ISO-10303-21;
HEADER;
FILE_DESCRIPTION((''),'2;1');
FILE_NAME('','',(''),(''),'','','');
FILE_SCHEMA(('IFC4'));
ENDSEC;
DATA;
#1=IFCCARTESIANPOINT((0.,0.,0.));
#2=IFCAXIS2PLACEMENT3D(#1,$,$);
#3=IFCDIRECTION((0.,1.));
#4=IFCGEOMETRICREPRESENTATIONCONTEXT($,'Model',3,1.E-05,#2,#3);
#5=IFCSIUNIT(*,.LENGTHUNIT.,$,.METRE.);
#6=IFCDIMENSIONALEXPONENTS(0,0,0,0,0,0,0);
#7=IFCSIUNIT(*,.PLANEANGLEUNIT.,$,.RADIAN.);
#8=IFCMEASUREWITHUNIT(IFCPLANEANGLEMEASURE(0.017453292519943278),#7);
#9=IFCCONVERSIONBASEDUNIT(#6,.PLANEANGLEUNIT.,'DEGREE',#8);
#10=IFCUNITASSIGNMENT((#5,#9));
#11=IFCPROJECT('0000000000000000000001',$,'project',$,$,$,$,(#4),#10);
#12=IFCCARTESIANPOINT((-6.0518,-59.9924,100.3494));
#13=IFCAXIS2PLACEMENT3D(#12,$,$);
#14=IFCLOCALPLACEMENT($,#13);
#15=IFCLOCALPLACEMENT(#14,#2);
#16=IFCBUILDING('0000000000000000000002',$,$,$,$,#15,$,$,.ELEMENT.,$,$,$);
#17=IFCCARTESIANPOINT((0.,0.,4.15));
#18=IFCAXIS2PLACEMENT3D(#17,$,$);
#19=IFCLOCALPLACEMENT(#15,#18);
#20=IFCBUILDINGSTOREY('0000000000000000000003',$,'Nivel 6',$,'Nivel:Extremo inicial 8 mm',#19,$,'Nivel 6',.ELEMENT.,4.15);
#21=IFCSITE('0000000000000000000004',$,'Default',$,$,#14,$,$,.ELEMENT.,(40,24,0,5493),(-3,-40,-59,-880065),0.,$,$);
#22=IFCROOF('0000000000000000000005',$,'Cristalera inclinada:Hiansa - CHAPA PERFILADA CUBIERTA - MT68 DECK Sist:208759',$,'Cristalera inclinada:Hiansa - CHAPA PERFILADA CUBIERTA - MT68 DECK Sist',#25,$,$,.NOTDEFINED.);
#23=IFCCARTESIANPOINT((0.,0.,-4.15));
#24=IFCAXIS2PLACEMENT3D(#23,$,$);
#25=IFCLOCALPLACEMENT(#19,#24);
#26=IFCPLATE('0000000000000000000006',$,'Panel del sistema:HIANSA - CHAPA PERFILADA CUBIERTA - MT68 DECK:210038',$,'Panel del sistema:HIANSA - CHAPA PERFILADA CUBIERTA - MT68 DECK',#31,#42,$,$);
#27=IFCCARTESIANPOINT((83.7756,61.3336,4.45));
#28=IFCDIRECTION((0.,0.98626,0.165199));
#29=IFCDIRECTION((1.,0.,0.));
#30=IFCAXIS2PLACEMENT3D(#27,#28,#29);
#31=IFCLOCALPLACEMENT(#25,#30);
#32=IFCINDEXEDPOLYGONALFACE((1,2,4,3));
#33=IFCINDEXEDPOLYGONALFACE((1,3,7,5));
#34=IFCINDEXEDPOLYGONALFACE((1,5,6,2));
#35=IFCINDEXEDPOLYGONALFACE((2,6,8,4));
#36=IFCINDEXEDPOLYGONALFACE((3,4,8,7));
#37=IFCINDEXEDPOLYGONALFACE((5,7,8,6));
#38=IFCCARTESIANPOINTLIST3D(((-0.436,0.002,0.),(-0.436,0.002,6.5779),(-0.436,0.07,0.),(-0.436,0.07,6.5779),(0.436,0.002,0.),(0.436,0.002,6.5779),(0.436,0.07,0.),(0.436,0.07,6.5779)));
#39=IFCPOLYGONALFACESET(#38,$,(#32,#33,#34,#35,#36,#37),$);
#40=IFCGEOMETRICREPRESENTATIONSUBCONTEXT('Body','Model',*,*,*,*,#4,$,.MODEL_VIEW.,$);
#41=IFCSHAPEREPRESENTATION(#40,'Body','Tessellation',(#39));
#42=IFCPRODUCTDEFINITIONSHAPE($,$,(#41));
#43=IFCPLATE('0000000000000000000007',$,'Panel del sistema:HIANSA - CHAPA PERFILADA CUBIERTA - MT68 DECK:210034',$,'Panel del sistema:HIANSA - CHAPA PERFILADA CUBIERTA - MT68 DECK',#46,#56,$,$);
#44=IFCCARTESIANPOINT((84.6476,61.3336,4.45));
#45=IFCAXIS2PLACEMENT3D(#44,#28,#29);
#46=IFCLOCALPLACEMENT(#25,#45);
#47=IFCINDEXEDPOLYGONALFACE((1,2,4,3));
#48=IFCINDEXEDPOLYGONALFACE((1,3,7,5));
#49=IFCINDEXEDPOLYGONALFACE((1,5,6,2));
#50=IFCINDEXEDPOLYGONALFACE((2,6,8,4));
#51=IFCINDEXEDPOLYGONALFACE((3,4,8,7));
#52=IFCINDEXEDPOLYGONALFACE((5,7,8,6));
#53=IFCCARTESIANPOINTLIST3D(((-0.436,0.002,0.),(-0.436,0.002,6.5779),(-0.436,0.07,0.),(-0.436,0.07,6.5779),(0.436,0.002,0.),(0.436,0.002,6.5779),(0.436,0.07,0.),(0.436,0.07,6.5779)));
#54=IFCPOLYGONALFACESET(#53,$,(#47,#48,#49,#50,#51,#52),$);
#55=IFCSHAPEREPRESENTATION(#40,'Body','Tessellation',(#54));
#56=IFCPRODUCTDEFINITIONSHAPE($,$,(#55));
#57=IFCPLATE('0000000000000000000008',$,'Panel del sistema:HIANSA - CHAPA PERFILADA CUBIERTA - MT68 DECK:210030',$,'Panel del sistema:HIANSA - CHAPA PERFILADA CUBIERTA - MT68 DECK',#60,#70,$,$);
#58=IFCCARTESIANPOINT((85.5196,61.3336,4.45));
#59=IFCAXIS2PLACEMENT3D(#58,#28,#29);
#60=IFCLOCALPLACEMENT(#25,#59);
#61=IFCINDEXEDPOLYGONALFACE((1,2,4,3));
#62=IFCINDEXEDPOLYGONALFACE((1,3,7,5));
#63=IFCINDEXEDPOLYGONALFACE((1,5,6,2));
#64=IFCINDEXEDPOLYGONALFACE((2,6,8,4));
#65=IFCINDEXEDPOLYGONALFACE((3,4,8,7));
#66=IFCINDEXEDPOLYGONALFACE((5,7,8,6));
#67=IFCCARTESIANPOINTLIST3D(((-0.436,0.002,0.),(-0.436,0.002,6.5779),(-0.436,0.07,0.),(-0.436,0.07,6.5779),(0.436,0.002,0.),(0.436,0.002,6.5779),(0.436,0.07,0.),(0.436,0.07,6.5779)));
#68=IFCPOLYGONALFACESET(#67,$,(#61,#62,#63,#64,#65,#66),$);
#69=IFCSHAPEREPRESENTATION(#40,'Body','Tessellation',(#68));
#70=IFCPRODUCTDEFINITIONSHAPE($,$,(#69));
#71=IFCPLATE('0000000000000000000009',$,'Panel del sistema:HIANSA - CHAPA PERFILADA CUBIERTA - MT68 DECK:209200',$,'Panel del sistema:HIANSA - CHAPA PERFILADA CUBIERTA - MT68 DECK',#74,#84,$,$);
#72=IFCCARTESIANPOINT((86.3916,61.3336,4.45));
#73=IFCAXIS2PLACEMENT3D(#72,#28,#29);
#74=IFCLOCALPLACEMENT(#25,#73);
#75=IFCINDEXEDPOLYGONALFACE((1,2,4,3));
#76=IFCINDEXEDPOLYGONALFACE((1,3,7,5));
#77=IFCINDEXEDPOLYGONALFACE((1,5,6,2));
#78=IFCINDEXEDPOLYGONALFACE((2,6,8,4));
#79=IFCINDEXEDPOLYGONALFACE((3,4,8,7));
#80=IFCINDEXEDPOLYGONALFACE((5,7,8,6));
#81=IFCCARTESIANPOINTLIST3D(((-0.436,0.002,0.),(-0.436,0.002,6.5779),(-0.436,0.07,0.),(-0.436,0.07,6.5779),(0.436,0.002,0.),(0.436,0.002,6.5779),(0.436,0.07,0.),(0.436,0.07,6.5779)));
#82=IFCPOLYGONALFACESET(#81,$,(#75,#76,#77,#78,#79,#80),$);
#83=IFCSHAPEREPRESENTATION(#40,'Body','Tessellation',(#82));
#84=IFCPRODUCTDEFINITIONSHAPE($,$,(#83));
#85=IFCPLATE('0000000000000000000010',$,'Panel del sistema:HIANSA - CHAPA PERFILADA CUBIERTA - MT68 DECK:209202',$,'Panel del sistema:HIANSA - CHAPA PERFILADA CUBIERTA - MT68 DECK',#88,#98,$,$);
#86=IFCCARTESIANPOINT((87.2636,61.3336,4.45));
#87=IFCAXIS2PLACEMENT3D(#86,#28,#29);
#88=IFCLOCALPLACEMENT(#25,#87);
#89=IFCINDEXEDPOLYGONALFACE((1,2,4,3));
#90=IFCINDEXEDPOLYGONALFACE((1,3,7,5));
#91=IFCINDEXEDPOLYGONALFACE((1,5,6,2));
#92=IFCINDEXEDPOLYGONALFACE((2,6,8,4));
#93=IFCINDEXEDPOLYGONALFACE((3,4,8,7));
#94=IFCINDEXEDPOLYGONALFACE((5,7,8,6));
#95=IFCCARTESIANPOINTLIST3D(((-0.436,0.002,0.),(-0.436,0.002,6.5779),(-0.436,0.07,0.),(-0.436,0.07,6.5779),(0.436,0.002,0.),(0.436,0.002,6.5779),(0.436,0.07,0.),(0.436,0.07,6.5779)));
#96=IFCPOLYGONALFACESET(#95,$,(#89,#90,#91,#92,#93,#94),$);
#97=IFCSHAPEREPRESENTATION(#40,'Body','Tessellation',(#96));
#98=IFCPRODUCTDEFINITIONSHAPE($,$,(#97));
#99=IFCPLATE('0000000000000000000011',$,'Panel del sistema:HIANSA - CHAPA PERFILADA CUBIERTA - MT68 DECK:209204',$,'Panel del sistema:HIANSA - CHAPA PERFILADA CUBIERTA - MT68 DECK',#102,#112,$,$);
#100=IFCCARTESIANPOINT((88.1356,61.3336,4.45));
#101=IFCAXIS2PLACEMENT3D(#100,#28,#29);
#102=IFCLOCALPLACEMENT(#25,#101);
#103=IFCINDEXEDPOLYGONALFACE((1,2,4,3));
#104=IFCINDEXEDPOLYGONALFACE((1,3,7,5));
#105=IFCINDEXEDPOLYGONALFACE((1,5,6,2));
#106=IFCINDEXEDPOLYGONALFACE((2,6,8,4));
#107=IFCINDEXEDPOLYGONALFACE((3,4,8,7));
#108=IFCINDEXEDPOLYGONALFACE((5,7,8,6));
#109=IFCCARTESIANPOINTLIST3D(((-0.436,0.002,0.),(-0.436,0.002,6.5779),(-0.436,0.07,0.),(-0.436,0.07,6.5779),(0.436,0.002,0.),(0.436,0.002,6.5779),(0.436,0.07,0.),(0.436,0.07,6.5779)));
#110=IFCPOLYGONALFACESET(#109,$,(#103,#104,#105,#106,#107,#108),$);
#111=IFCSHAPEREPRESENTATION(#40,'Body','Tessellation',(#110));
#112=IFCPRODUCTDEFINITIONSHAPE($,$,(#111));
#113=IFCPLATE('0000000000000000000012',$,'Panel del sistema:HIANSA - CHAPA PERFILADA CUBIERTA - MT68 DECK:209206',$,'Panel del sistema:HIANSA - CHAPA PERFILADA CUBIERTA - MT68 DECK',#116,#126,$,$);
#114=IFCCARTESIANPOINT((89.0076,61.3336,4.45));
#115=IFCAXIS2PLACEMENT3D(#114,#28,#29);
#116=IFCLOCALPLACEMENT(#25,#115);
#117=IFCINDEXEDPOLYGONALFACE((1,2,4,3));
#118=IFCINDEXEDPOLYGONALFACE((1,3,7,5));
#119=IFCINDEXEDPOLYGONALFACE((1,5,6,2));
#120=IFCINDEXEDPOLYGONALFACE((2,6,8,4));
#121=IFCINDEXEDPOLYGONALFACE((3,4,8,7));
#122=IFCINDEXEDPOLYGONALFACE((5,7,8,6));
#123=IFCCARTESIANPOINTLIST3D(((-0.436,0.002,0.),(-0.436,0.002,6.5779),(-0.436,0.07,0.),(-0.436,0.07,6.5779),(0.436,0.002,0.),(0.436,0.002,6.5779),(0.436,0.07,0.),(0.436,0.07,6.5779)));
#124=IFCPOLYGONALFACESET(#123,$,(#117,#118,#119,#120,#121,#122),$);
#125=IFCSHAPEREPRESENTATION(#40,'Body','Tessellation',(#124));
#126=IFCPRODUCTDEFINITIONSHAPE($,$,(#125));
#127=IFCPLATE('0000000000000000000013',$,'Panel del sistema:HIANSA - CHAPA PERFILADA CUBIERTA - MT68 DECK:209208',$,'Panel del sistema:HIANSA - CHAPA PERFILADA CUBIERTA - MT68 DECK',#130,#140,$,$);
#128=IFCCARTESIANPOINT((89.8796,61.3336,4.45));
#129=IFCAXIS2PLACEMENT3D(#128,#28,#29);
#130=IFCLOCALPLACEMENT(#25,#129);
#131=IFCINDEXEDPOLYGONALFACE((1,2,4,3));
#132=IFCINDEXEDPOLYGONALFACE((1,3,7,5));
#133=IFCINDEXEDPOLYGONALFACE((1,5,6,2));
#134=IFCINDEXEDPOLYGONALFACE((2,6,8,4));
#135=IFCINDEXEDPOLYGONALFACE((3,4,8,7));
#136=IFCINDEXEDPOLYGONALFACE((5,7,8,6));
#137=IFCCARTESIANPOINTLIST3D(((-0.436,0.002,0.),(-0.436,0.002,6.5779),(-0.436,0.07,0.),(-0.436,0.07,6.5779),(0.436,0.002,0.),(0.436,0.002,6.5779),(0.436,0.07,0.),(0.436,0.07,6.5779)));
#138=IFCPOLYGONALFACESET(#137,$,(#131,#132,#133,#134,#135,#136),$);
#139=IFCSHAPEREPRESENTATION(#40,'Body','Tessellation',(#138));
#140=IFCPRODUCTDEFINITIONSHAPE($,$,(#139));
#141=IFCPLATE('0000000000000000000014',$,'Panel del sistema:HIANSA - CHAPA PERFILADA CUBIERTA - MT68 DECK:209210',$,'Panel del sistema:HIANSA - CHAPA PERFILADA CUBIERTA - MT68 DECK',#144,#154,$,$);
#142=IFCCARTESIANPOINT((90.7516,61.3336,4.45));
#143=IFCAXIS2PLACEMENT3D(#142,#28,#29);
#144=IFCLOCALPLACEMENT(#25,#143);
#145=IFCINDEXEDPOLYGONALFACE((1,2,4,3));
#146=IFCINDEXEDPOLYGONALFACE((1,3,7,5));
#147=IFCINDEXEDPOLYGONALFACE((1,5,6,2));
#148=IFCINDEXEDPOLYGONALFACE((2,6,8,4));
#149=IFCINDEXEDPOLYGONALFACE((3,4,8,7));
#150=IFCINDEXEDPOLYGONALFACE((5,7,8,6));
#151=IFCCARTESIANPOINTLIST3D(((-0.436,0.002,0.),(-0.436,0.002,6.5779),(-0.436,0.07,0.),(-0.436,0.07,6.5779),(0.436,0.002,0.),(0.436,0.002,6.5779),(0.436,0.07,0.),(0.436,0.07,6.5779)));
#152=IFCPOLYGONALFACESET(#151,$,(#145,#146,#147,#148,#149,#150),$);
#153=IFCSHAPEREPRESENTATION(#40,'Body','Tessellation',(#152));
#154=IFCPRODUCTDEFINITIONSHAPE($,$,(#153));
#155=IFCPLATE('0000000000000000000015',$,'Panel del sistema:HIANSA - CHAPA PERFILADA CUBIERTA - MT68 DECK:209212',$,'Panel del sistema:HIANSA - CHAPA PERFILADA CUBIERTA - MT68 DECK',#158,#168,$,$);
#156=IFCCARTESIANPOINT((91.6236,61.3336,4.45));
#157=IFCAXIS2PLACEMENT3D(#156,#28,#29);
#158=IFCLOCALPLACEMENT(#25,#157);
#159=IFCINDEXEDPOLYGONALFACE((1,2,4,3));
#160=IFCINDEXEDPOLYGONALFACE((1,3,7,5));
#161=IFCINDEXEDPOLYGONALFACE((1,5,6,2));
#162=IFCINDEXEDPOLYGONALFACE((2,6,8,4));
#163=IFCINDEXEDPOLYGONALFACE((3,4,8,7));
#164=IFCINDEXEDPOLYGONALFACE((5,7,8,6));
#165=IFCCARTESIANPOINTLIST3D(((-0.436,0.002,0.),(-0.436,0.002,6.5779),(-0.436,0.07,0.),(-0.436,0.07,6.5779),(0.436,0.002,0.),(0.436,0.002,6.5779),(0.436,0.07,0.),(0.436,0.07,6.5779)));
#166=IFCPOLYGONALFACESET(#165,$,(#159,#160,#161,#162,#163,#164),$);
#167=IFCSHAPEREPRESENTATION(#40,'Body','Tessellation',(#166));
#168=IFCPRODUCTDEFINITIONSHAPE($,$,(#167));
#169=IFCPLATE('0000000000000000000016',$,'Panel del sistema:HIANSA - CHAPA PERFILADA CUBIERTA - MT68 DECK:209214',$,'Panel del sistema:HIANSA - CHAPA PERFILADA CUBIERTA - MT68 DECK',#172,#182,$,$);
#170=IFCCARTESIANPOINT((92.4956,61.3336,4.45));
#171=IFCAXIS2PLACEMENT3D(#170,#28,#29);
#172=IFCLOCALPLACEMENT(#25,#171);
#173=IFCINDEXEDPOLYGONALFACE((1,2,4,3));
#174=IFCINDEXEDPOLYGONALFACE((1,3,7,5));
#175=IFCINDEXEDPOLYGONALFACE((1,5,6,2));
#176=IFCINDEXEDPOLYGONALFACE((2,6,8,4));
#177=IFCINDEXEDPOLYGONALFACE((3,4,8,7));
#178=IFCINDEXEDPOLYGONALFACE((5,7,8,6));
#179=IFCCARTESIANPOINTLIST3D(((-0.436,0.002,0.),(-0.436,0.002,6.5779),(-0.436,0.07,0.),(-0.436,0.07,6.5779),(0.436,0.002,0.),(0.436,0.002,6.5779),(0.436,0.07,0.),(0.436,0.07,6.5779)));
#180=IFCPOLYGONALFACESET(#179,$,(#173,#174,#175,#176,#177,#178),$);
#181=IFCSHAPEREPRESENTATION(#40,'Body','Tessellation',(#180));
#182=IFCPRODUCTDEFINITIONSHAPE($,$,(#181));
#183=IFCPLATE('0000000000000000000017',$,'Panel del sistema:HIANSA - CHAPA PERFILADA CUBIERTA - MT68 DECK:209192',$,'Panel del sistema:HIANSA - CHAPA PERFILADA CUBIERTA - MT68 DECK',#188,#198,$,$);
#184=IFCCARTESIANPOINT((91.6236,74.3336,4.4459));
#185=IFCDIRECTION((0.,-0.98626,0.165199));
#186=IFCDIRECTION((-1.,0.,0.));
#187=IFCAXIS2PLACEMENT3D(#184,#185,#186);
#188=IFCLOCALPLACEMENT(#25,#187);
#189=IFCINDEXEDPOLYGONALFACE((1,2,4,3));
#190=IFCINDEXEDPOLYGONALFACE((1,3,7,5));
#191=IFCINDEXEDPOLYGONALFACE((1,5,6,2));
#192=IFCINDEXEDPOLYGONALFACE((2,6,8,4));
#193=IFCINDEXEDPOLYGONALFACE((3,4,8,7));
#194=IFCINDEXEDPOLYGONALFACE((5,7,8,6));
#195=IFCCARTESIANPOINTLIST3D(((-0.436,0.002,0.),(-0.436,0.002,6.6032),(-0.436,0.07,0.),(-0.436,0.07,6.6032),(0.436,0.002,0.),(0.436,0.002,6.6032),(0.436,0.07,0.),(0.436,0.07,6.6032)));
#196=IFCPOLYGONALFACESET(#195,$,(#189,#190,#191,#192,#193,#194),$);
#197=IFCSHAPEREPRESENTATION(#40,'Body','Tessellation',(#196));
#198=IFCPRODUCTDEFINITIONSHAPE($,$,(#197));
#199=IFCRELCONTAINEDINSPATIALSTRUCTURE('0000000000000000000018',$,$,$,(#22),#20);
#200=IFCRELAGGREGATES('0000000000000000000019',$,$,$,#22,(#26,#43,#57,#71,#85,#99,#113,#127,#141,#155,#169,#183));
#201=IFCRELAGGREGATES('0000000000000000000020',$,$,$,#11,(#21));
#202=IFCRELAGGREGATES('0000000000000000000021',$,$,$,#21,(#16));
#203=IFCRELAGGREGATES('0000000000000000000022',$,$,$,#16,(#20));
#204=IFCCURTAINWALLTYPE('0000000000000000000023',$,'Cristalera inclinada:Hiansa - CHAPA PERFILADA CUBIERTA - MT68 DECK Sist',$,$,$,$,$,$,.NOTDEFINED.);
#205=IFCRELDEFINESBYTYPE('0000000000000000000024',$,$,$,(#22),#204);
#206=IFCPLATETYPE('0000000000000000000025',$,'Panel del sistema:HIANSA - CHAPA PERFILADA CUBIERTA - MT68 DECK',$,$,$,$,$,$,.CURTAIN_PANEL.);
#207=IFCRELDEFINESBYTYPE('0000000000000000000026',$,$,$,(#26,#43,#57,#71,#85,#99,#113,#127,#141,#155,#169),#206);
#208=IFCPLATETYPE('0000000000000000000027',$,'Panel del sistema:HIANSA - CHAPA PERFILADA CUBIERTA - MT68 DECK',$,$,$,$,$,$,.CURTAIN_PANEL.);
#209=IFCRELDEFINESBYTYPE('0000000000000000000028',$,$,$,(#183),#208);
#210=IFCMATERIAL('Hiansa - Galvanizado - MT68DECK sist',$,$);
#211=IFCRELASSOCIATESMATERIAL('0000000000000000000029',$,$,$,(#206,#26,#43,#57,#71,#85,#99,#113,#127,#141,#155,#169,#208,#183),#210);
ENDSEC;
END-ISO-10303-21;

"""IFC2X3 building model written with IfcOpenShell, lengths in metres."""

from ifc_helpers import new_model, entity, si_unit, converted_unit, direction, frame, origin, origin_2d_with_axis, place, context, subcontext, project, spatial, rectangle, extrude, source, transform, mapped, material, type_object, type_shapes, element, aggregate, save


model = new_model("IFC2X3")

# Units and contexts
model_context = context("Model", 3, precision=1e-05, world=origin(), true_north=direction((0.0, 1.0)))
body_context = subcontext(model_context, "Body", "Model", "MODEL_VIEW")
ifc_project = project(units=[si_unit("LENGTHUNIT", "METRE"), converted_unit("PLANEANGLEUNIT", "DEGREE", entity("IfcPlaneAngleMeasure", 0.017453292519943278), si_unit("PLANEANGLEUNIT", "RADIAN"), dimensions=[0, 0, 0, 0, 0, 0, 0])], contexts=[model_context])

# Site, building, storey
site_placement = place(None, frame((-6.0518, -59.9924, 100.3494)))
site = spatial("IfcSite", under=ifc_project, at=site_placement, Name="Default", CompositionType="ELEMENT", RefLatitude=(40, 24, 0, 5493), RefLongitude=(-3, -40, -59, -880065), RefElevation=0.0)
building_placement = place(site_placement, origin())
building = spatial("IfcBuilding", under=site, at=building_placement, CompositionType="ELEMENT")
storey_placement = place(building_placement, frame((0.0, 0.0, 4.15)))
storey = spatial("IfcBuildingStorey", under=building, at=storey_placement, Name="Nivel 6", ObjectType="Nivel:Extremo inicial 8 mm", LongName="Nivel 6", CompositionType="ELEMENT", Elevation=4.15)

# Roof, plates
curtain_wall_type = type_object("IfcCurtainWallType", Name="Cristalera inclinada:Hiansa - CHAPA PERFILADA CUBIERTA - MT68 DECK Sist", PredefinedType="NOTDEFINED")
roof_placement = place(storey_placement, frame((0.0, 0.0, -4.15)))
roof = element("IfcRoof", 1, at=roof_placement, inside=storey, type_object=curtain_wall_type, Name="Cristalera inclinada:Hiansa - CHAPA PERFILADA CUBIERTA - MT68 DECK Sist:208759", ObjectType="Cristalera inclinada:Hiansa - CHAPA PERFILADA CUBIERTA - MT68 DECK Sist", ShapeType="NOTDEFINED")
ifc_material_1 = material(Name="Hiansa - Galvanizado - MT68DECK sist")
plate_type_1 = type_object("IfcPlateType", Name="Panel del sistema:HIANSA - CHAPA PERFILADA CUBIERTA - MT68 DECK", PredefinedType="CURTAIN_PANEL", material=ifc_material_1)
shared_shape_1 = source(origin(), body_context, "Body", "SweptSolid", [
    extrude(rectangle(XDim=0.068, YDim=0.872, at=origin_2d_with_axis()), frame((0.0, 0.036, 0.0), z_axis=(0.0, 0.0, 1.0), x_axis=(0.0, 1.0, 0.0)), (0.0, 0.0, 1.0), 6.5779),
])
type_shapes(plate_type_1, [shared_shape_1])
plate_1_placement = place(roof_placement, frame((83.7756, 61.3336, 4.45), z_axis=(0.0, 0.98626, 0.165199), x_axis=(1.0, 0.0, 0.0)))
plate_1 = element("IfcPlate", 2, at=plate_1_placement, type_object=plate_type_1, material=ifc_material_1, Name="Panel del sistema:HIANSA - CHAPA PERFILADA CUBIERTA - MT68 DECK:210038", ObjectType="Panel del sistema:HIANSA - CHAPA PERFILADA CUBIERTA - MT68 DECK", context=body_context, shape_type="MappedRepresentation", body=[
    mapped(shared_shape_1, transform((0.0, 0.0, 0.0), scale=1.0)),
])
plate_2_placement = place(roof_placement, frame((84.6476, 61.3336, 4.45), z_axis=(0.0, 0.98626, 0.165199), x_axis=(1.0, 0.0, 0.0)))
plate_2 = element("IfcPlate", 3, at=plate_2_placement, type_object=plate_type_1, material=ifc_material_1, Name="Panel del sistema:HIANSA - CHAPA PERFILADA CUBIERTA - MT68 DECK:210034", ObjectType="Panel del sistema:HIANSA - CHAPA PERFILADA CUBIERTA - MT68 DECK", context=body_context, shape_type="MappedRepresentation", body=[
    mapped(shared_shape_1, transform((0.0, 0.0, 0.0), scale=1.0)),
])
plate_3_placement = place(roof_placement, frame((85.5196, 61.3336, 4.45), z_axis=(0.0, 0.98626, 0.165199), x_axis=(1.0, 0.0, 0.0)))
plate_3 = element("IfcPlate", 4, at=plate_3_placement, type_object=plate_type_1, material=ifc_material_1, Name="Panel del sistema:HIANSA - CHAPA PERFILADA CUBIERTA - MT68 DECK:210030", ObjectType="Panel del sistema:HIANSA - CHAPA PERFILADA CUBIERTA - MT68 DECK", context=body_context, shape_type="MappedRepresentation", body=[
    mapped(shared_shape_1, transform((0.0, 0.0, 0.0), scale=1.0)),
])
plate_4_placement = place(roof_placement, frame((86.3916, 61.3336, 4.45), z_axis=(0.0, 0.98626, 0.165199), x_axis=(1.0, 0.0, 0.0)))
plate_4 = element("IfcPlate", 5, at=plate_4_placement, type_object=plate_type_1, material=ifc_material_1, Name="Panel del sistema:HIANSA - CHAPA PERFILADA CUBIERTA - MT68 DECK:209200", ObjectType="Panel del sistema:HIANSA - CHAPA PERFILADA CUBIERTA - MT68 DECK", context=body_context, shape_type="MappedRepresentation", body=[
    mapped(shared_shape_1, transform((0.0, 0.0, 0.0), scale=1.0)),
])
plate_5_placement = place(roof_placement, frame((87.2636, 61.3336, 4.45), z_axis=(0.0, 0.98626, 0.165199), x_axis=(1.0, 0.0, 0.0)))
plate_5 = element("IfcPlate", 6, at=plate_5_placement, type_object=plate_type_1, material=ifc_material_1, Name="Panel del sistema:HIANSA - CHAPA PERFILADA CUBIERTA - MT68 DECK:209202", ObjectType="Panel del sistema:HIANSA - CHAPA PERFILADA CUBIERTA - MT68 DECK", context=body_context, shape_type="MappedRepresentation", body=[
    mapped(shared_shape_1, transform((0.0, 0.0, 0.0), scale=1.0)),
])
plate_6_placement = place(roof_placement, frame((88.1356, 61.3336, 4.45), z_axis=(0.0, 0.98626, 0.165199), x_axis=(1.0, 0.0, 0.0)))
plate_6 = element("IfcPlate", 7, at=plate_6_placement, type_object=plate_type_1, material=ifc_material_1, Name="Panel del sistema:HIANSA - CHAPA PERFILADA CUBIERTA - MT68 DECK:209204", ObjectType="Panel del sistema:HIANSA - CHAPA PERFILADA CUBIERTA - MT68 DECK", context=body_context, shape_type="MappedRepresentation", body=[
    mapped(shared_shape_1, transform((0.0, 0.0, 0.0), scale=1.0)),
])
plate_7_placement = place(roof_placement, frame((89.0076, 61.3336, 4.45), z_axis=(0.0, 0.98626, 0.165199), x_axis=(1.0, 0.0, 0.0)))
plate_7 = element("IfcPlate", 8, at=plate_7_placement, type_object=plate_type_1, material=ifc_material_1, Name="Panel del sistema:HIANSA - CHAPA PERFILADA CUBIERTA - MT68 DECK:209206", ObjectType="Panel del sistema:HIANSA - CHAPA PERFILADA CUBIERTA - MT68 DECK", context=body_context, shape_type="MappedRepresentation", body=[
    mapped(shared_shape_1, transform((0.0, 0.0, 0.0), scale=1.0)),
])
plate_8_placement = place(roof_placement, frame((89.8796, 61.3336, 4.45), z_axis=(0.0, 0.98626, 0.165199), x_axis=(1.0, 0.0, 0.0)))
plate_8 = element("IfcPlate", 9, at=plate_8_placement, type_object=plate_type_1, material=ifc_material_1, Name="Panel del sistema:HIANSA - CHAPA PERFILADA CUBIERTA - MT68 DECK:209208", ObjectType="Panel del sistema:HIANSA - CHAPA PERFILADA CUBIERTA - MT68 DECK", context=body_context, shape_type="MappedRepresentation", body=[
    mapped(shared_shape_1, transform((0.0, 0.0, 0.0), scale=1.0)),
])
plate_9_placement = place(roof_placement, frame((90.7516, 61.3336, 4.45), z_axis=(0.0, 0.98626, 0.165199), x_axis=(1.0, 0.0, 0.0)))
plate_9 = element("IfcPlate", 10, at=plate_9_placement, type_object=plate_type_1, material=ifc_material_1, Name="Panel del sistema:HIANSA - CHAPA PERFILADA CUBIERTA - MT68 DECK:209210", ObjectType="Panel del sistema:HIANSA - CHAPA PERFILADA CUBIERTA - MT68 DECK", context=body_context, shape_type="MappedRepresentation", body=[
    mapped(shared_shape_1, transform((0.0, 0.0, 0.0), scale=1.0)),
])
plate_10_placement = place(roof_placement, frame((91.6236, 61.3336, 4.45), z_axis=(0.0, 0.98626, 0.165199), x_axis=(1.0, 0.0, 0.0)))
plate_10 = element("IfcPlate", 11, at=plate_10_placement, type_object=plate_type_1, material=ifc_material_1, Name="Panel del sistema:HIANSA - CHAPA PERFILADA CUBIERTA - MT68 DECK:209212", ObjectType="Panel del sistema:HIANSA - CHAPA PERFILADA CUBIERTA - MT68 DECK", context=body_context, shape_type="MappedRepresentation", body=[
    mapped(shared_shape_1, transform((0.0, 0.0, 0.0), scale=1.0)),
])
plate_11_placement = place(roof_placement, frame((92.4956, 61.3336, 4.45), z_axis=(0.0, 0.98626, 0.165199), x_axis=(1.0, 0.0, 0.0)))
plate_11 = element("IfcPlate", 12, at=plate_11_placement, type_object=plate_type_1, material=ifc_material_1, Name="Panel del sistema:HIANSA - CHAPA PERFILADA CUBIERTA - MT68 DECK:209214", ObjectType="Panel del sistema:HIANSA - CHAPA PERFILADA CUBIERTA - MT68 DECK", context=body_context, shape_type="MappedRepresentation", body=[
    mapped(shared_shape_1, transform((0.0, 0.0, 0.0), scale=1.0)),
])
plate_type_2 = type_object("IfcPlateType", Name="Panel del sistema:HIANSA - CHAPA PERFILADA CUBIERTA - MT68 DECK", PredefinedType="CURTAIN_PANEL", material=ifc_material_1)
shared_shape_2 = source(origin(), body_context, "Body", "SweptSolid", [
    extrude(rectangle(XDim=0.068, YDim=0.872, at=origin_2d_with_axis()), frame((0.0, 0.036, 0.0), z_axis=(0.0, 0.0, 1.0), x_axis=(0.0, 1.0, 0.0)), (0.0, 0.0, 1.0), 6.6032),
])
type_shapes(plate_type_2, [shared_shape_2])
plate_12_placement = place(roof_placement, frame((91.6236, 74.3336, 4.4459), z_axis=(0.0, -0.98626, 0.165199), x_axis=(-1.0, 0.0, 0.0)))
plate_12 = element("IfcPlate", 13, at=plate_12_placement, type_object=plate_type_2, material=ifc_material_1, Name="Panel del sistema:HIANSA - CHAPA PERFILADA CUBIERTA - MT68 DECK:209192", ObjectType="Panel del sistema:HIANSA - CHAPA PERFILADA CUBIERTA - MT68 DECK", context=body_context, shape_type="MappedRepresentation", body=[
    mapped(shared_shape_2, transform((0.0, 0.0, 0.0), scale=1.0)),
])
aggregate(roof, [plate_1, plate_2, plate_3, plate_4, plate_5, plate_6, plate_7, plate_8, plate_9, plate_10, plate_11, plate_12])

save(model, "model.ifc")
